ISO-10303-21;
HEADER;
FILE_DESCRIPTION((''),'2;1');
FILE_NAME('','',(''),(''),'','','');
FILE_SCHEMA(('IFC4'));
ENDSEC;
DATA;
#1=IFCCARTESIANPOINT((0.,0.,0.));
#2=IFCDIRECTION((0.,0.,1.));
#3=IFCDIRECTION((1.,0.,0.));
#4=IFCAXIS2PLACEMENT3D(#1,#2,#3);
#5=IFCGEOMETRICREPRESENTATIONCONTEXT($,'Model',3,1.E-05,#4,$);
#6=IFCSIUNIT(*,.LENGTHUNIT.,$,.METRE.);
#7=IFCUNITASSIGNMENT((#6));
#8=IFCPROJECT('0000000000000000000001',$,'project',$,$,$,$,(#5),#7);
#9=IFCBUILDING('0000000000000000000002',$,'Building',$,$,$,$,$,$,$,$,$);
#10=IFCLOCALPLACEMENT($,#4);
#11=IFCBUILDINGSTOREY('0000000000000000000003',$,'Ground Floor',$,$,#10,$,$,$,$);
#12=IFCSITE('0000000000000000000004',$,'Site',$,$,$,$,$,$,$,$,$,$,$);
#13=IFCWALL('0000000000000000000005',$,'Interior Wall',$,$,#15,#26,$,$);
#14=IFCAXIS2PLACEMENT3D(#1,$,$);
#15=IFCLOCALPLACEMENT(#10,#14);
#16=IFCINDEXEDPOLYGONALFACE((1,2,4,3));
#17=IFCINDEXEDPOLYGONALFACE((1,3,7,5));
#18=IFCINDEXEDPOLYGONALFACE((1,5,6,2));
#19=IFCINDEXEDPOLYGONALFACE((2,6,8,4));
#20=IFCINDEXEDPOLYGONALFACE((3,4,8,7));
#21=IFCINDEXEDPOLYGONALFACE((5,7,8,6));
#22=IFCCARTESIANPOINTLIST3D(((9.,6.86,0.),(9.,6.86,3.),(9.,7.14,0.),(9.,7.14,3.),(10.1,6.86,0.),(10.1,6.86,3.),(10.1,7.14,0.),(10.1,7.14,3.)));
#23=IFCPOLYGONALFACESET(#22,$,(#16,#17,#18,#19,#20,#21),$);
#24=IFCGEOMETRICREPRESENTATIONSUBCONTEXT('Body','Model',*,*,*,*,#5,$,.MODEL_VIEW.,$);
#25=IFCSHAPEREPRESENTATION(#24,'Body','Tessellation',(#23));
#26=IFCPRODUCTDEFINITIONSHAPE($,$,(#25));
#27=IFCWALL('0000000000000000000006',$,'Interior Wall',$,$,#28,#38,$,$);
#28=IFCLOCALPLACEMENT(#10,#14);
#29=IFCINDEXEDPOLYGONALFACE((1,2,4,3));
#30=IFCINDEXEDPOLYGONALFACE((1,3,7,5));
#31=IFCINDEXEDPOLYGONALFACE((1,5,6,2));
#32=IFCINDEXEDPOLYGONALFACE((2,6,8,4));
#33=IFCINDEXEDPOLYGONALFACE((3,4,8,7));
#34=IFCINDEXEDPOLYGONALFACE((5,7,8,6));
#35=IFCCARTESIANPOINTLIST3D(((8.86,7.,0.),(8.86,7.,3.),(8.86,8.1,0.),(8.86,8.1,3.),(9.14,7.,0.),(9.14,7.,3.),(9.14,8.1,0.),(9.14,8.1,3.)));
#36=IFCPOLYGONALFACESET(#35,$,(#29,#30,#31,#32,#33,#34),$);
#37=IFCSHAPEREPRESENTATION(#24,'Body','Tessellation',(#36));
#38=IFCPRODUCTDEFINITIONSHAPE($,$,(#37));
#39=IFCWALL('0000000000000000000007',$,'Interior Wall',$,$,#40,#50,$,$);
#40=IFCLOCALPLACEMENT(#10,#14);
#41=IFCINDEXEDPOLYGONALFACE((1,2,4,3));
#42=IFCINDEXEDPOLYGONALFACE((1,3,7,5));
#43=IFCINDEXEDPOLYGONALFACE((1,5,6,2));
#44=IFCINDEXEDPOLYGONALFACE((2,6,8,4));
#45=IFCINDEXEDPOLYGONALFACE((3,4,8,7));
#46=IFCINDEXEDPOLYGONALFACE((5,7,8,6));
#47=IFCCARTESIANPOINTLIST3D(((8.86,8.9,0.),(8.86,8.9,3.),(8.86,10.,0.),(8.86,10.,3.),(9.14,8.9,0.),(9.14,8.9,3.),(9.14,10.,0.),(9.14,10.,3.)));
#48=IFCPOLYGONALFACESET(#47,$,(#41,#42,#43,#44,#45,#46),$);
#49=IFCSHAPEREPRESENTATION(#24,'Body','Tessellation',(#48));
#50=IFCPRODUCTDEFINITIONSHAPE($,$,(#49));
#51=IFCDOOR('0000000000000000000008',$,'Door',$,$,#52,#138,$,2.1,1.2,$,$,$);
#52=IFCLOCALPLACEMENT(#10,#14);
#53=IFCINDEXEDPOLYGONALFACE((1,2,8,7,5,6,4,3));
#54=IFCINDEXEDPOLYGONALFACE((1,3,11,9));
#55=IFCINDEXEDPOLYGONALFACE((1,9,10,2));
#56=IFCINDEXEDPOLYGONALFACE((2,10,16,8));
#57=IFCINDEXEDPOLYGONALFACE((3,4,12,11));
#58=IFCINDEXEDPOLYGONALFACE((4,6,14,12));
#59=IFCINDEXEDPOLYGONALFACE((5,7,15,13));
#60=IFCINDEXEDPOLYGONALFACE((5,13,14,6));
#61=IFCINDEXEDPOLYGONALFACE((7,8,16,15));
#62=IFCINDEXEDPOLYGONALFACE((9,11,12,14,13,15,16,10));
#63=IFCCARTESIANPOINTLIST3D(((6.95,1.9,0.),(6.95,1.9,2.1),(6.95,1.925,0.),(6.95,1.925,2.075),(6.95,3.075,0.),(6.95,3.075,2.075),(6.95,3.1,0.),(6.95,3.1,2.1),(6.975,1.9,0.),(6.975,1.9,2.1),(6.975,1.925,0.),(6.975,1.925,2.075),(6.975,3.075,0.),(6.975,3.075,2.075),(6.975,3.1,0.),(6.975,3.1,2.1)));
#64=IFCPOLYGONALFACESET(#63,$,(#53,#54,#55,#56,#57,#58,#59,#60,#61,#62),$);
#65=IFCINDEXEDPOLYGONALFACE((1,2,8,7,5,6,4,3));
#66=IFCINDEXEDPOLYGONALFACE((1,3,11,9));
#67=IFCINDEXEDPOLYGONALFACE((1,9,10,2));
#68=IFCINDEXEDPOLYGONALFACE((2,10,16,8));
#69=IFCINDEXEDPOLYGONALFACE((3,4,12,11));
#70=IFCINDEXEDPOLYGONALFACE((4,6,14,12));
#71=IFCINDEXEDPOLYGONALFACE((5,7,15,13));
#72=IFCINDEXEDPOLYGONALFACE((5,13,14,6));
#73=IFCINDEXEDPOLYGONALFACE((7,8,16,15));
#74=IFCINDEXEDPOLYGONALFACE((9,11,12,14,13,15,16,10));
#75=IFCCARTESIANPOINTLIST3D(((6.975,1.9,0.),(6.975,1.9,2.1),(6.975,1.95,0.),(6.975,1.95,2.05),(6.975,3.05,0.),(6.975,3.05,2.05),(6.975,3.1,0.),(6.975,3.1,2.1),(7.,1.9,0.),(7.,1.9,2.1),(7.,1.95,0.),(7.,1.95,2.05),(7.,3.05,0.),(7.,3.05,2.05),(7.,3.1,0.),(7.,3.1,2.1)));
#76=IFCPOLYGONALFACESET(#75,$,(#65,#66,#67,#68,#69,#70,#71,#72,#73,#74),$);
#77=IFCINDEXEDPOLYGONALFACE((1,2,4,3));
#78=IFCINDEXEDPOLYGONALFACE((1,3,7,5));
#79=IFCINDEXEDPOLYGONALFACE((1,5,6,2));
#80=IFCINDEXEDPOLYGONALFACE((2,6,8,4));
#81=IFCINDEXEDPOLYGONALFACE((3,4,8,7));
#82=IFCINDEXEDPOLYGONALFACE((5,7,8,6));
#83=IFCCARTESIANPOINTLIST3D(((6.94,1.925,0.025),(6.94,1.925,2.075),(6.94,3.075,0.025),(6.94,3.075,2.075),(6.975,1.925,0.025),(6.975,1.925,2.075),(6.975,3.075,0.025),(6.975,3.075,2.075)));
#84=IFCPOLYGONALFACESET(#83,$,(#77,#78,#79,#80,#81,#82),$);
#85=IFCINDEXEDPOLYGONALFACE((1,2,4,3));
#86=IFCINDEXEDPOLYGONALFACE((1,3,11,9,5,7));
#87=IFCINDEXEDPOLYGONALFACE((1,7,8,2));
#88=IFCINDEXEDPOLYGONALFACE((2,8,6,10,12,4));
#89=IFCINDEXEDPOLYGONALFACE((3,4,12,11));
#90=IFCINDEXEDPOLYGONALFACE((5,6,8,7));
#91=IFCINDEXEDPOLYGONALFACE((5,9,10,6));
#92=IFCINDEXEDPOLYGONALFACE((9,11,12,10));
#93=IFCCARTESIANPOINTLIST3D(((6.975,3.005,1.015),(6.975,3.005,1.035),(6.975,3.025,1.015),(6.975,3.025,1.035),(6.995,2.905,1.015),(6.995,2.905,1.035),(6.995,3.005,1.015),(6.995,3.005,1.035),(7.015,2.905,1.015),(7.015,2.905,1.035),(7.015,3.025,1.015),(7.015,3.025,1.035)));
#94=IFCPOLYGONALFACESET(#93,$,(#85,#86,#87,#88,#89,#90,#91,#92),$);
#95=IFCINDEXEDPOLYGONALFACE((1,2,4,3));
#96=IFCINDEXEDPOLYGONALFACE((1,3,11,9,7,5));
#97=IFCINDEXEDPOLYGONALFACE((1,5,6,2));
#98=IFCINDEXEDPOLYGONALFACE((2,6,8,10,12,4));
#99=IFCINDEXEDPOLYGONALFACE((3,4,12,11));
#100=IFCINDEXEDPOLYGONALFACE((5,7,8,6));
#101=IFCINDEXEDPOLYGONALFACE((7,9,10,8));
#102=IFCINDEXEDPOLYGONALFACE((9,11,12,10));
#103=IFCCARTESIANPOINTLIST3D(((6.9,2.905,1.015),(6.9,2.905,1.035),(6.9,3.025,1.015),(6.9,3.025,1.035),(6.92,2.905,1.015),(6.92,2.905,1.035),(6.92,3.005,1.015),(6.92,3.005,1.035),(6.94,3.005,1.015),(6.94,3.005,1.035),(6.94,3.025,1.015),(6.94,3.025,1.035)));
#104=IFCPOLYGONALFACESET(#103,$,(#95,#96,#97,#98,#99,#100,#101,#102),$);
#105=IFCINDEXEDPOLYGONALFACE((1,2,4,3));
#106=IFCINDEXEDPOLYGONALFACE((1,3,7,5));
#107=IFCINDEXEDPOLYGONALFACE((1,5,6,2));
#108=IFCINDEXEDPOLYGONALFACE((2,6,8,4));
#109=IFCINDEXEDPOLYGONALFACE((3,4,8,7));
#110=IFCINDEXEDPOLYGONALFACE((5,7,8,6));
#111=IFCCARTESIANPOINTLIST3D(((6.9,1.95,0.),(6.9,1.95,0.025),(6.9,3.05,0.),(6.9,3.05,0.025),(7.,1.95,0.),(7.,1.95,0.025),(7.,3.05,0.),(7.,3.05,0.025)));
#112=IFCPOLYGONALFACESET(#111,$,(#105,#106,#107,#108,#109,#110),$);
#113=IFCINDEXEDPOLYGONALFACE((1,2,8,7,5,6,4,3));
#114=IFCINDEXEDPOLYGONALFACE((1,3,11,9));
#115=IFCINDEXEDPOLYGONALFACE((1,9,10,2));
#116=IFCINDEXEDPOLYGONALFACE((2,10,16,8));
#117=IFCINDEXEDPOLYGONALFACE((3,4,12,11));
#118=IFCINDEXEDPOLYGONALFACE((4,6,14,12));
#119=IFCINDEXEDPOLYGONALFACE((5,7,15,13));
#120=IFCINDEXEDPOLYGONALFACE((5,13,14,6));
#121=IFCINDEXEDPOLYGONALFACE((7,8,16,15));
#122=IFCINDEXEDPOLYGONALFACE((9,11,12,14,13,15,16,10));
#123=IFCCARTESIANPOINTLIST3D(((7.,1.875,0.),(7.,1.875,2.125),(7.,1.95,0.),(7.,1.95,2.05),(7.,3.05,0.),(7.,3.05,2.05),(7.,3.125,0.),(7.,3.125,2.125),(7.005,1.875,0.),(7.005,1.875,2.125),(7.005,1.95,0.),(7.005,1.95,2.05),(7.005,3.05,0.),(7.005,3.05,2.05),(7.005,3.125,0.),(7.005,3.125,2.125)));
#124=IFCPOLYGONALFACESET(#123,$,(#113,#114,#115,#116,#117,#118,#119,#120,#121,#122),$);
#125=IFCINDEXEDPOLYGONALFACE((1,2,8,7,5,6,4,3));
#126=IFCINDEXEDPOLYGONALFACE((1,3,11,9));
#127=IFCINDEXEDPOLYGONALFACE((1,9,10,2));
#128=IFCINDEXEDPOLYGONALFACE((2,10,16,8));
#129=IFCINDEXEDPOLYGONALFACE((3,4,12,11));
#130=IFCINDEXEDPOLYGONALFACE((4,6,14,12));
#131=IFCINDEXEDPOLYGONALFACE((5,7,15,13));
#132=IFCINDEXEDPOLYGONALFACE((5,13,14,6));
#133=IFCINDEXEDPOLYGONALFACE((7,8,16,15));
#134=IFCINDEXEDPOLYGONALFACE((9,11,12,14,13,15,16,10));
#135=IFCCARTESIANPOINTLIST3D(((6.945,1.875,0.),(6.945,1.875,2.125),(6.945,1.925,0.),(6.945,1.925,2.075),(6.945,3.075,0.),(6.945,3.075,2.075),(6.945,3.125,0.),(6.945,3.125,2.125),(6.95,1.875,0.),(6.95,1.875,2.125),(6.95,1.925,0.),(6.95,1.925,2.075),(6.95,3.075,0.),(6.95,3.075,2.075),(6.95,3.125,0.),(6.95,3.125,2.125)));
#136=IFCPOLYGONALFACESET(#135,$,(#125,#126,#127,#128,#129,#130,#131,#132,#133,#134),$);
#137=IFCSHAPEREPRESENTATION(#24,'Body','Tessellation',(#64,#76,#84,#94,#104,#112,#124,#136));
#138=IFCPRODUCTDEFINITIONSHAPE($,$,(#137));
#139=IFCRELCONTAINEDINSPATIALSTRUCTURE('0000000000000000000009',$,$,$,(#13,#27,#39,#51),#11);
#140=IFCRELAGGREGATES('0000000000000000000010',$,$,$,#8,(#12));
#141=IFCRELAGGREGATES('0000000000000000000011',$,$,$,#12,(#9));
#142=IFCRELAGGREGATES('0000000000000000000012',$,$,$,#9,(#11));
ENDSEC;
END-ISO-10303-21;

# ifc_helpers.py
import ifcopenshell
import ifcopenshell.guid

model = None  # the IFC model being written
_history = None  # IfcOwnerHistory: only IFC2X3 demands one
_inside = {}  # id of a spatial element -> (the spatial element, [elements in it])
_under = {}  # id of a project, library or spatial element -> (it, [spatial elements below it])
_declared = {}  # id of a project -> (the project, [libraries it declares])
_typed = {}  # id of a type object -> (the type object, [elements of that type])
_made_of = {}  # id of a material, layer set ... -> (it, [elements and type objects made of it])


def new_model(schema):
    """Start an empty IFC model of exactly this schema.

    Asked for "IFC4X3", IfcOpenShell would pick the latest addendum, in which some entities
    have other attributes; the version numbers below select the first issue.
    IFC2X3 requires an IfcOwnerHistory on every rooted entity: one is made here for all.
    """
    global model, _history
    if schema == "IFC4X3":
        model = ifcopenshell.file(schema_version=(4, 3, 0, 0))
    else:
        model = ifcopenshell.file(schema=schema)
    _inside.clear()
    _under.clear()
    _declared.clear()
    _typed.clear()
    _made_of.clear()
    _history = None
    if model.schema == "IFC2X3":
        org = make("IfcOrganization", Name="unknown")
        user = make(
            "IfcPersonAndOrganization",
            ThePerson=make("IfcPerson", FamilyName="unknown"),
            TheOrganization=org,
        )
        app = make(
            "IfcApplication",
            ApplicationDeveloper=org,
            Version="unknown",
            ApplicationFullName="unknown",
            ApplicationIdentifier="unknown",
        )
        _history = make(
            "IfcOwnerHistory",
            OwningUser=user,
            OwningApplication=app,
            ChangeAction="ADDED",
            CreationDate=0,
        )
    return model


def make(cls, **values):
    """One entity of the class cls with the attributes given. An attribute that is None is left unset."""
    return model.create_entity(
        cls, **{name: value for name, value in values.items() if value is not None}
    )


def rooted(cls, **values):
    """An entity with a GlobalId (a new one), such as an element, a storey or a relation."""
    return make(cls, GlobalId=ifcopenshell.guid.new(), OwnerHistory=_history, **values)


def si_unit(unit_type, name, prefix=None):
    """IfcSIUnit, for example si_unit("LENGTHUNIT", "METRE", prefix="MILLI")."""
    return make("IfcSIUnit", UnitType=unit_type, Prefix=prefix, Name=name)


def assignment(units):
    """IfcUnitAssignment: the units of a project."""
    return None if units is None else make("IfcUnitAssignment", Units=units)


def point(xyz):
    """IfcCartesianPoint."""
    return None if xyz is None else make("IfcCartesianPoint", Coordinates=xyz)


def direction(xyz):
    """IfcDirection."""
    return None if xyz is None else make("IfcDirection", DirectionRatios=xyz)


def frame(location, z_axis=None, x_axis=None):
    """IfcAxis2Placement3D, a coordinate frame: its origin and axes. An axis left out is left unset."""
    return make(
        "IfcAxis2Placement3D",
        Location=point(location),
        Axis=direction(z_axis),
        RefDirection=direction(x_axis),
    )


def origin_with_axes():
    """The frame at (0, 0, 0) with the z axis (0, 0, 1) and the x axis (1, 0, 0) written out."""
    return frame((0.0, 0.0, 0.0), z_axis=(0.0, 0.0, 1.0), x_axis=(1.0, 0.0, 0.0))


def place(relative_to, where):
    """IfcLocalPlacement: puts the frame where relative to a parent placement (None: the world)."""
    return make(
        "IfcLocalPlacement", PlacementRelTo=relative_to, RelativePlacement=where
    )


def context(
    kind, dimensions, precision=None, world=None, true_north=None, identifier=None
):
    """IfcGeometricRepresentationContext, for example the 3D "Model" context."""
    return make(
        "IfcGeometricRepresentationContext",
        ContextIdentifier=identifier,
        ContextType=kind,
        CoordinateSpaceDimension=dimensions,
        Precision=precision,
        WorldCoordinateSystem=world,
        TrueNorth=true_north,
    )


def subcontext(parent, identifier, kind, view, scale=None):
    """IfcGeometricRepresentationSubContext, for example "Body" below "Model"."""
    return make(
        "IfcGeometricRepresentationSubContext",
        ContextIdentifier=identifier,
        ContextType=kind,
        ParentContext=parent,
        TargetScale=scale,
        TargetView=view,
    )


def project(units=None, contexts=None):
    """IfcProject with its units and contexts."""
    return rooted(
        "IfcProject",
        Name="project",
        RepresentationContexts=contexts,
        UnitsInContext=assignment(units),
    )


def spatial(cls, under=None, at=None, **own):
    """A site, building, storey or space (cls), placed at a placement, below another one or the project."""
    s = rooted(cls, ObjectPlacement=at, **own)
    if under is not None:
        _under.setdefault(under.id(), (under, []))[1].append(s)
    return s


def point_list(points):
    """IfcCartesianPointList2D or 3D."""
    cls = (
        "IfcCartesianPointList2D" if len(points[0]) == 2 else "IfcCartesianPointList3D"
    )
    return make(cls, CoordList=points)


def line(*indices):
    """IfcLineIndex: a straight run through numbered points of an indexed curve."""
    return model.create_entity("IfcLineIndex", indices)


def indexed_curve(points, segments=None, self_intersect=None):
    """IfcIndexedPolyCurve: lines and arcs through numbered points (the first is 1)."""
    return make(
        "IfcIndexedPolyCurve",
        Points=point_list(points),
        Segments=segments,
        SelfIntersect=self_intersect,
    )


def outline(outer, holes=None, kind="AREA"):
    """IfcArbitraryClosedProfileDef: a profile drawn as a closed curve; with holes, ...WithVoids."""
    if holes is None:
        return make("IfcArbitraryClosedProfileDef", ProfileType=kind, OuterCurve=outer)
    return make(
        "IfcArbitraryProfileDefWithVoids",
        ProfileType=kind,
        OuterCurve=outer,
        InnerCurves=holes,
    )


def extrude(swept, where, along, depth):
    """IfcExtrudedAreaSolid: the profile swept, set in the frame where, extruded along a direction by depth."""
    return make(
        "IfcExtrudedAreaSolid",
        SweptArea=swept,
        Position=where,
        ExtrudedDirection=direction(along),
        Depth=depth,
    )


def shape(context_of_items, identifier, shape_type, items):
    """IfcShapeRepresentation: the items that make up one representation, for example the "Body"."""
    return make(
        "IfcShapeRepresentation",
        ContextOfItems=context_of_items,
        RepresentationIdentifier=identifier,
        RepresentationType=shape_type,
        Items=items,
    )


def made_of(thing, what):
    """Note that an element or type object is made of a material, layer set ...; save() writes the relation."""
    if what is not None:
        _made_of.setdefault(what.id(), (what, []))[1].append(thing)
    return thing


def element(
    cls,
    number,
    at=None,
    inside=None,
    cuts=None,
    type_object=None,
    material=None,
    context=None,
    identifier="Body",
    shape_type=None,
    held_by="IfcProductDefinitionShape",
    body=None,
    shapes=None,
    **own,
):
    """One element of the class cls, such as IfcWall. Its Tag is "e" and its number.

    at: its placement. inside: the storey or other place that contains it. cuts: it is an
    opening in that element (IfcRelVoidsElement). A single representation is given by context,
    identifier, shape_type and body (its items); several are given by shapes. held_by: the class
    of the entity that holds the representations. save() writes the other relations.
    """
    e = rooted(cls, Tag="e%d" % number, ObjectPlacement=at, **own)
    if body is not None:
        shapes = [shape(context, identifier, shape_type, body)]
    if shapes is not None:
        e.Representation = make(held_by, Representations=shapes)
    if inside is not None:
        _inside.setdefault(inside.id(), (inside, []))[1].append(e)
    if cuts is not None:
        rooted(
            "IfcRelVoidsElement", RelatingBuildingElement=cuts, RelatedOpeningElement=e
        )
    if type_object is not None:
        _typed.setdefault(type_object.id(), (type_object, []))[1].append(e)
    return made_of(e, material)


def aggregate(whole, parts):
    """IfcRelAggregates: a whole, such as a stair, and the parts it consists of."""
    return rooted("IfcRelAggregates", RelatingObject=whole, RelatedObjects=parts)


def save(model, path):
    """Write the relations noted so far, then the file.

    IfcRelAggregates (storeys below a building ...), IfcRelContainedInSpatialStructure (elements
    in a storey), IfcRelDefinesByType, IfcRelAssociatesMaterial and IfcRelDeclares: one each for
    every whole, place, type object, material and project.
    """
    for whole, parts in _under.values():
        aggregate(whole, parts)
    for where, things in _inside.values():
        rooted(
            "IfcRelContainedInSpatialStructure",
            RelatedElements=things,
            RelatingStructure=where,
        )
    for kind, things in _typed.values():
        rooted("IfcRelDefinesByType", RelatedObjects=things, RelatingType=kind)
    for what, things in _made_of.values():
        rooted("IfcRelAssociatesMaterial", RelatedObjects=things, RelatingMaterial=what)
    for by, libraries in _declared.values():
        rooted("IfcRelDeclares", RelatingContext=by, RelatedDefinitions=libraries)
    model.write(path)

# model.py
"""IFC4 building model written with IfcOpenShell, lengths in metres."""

from ifc_helpers import new_model, si_unit, frame, origin_with_axes, place, context, subcontext, project, spatial, line, indexed_curve, outline, extrude, element, save


model = new_model("IFC4")

# Units and contexts
model_context = context("Model", 3, precision=1e-05, world=origin_with_axes())
body_context = subcontext(model_context, "Body", "Model", "MODEL_VIEW")
ifc_project = project(units=[si_unit("LENGTHUNIT", "METRE")], contexts=[model_context])

# Site, building, storey
site = spatial("IfcSite", under=ifc_project, Name="Site")
building = spatial("IfcBuilding", under=site, Name="Building")
storey_placement = place(None, origin_with_axes())
storey = spatial("IfcBuildingStorey", under=building, at=storey_placement, Name="Ground Floor")

# Walls
for number, where, z_axis, x_axis, name in (
    (1, (10.1, 7.0, 0.0), (0.0, 0.0, 1.0), (-1.0, 0.0, 0.0), "Interior Wall"),
    (2, (9.0, 7.0, 0.0), (0.0, 0.0, 1.0), (0.0, 1.0, 0.0), "Interior Wall"),
    (3, (9.0, 8.9, 0.0), (0.0, 0.0, 1.0), (0.0, 1.0, 0.0), "Interior Wall"),
):
    element("IfcWall", number, at=place(storey_placement, frame(where, z_axis=z_axis, x_axis=x_axis)), inside=storey, Name=name, context=body_context, shape_type="SweptSolid", body=[
        extrude(outline(indexed_curve([(0.0, 0.0), (0.0, 0.28), (1.1, 0.28), (1.1, 0.0), (0.0, 0.0)], self_intersect=False)), frame((0.0, -0.14, 0.0), z_axis=(0.0, 0.0, 1.0), x_axis=(1.0, 0.0, 0.0)), (0.0, 0.0, 1.0), 3.0),
    ])

# Door
door_1_placement = place(storey_placement, frame((7.0, 1.9, 0.0), z_axis=(0.0, 0.0, 1.0), x_axis=(0.0, 1.0, 0.0)))
element("IfcDoor", 4, at=door_1_placement, inside=storey, Name="Door", OverallHeight=2.1, OverallWidth=1.2, context=body_context, shape_type="SweptSolid", body=[
    extrude(outline(indexed_curve([(0.0, 0.0), (0.0, 2.1), (1.2, 2.1), (1.2, 0.0), (1.175, 0.0), (1.175, 2.075), (0.025, 2.075), (0.025, 0.0)], segments=[line(1, 2, 3, 4, 5, 6, 7, 8, 1)])), frame((0.0, 0.025, 0.0), z_axis=(0.0, -1.0, 0.0), x_axis=(1.0, 0.0, 0.0)), (0.0, 0.0, -1.0), 0.025),
    extrude(outline(indexed_curve([(0.0, 0.0), (0.0, 2.1), (1.2, 2.1), (1.2, 0.0), (1.15, 0.0), (1.15, 2.05), (0.05, 2.05), (0.05, 0.0)], segments=[line(1, 2, 3, 4, 5, 6, 7, 8, 1)])), frame((0.0, 0.0, 0.0), z_axis=(0.0, -1.0, 0.0), x_axis=(1.0, 0.0, 0.0)), (0.0, 0.0, -1.0), 0.025),
    extrude(outline(indexed_curve([(0.0, 0.0), (1.15, 0.0), (1.15, 0.035), (0.0, 0.035)], segments=[line(1, 2, 3, 4, 1)])), frame((0.025, 0.025, 0.025), z_axis=(0.0, 0.0, 1.0), x_axis=(1.0, 0.0, 0.0)), (0.0, 0.0, 1.0), 2.05),
    extrude(outline(indexed_curve([(0.0, 0.0), (0.0, -0.04), (-0.12, -0.04), (-0.12, -0.02), (-0.02, -0.02), (-0.02, 0.0)], segments=[line(1, 2, 3, 4, 5, 6, 1)])), frame((1.125, 0.025, 1.015), z_axis=(0.0, 0.0, 1.0), x_axis=(1.0, 0.0, 0.0)), (0.0, 0.0, 1.0), 0.02),
    extrude(outline(indexed_curve([(0.0, 0.0), (0.0, 0.04), (-0.12, 0.04), (-0.12, 0.02), (-0.02, 0.02), (-0.02, 0.0)], segments=[line(1, 2, 3, 4, 5, 6, 1)])), frame((1.125, 0.06, 1.015), z_axis=(0.0, 0.0, 1.0), x_axis=(1.0, 0.0, 0.0)), (0.0, 0.0, 1.0), 0.02),
    extrude(outline(indexed_curve([(0.0, 0.0), (1.1, 0.0), (1.1, 0.1), (0.0, 0.1)], segments=[line(1, 2, 3, 4, 1)])), frame((0.05, 0.0, 0.0), z_axis=(0.0, 0.0, 1.0), x_axis=(1.0, 0.0, 0.0)), (0.0, 0.0, 1.0), 0.025),
    extrude(outline(indexed_curve([(0.0, 0.0), (0.0, 2.125), (1.25, 2.125), (1.25, 0.0), (1.175, 0.0), (1.175, 2.05), (0.075, 2.05), (0.075, 0.0)], segments=[line(1, 2, 3, 4, 5, 6, 7, 8, 1)])), frame((-0.025, -0.005, 0.0), z_axis=(0.0, -1.0, 0.0), x_axis=(1.0, 0.0, 0.0)), (0.0, 0.0, -1.0), 0.005),
    extrude(outline(indexed_curve([(0.0, 0.0), (0.0, 2.125), (1.25, 2.125), (1.25, 0.0), (1.2, 0.0), (1.2, 2.075), (0.05, 2.075), (0.05, 0.0)], segments=[line(1, 2, 3, 4, 5, 6, 7, 8, 1)])), frame((-0.025, 0.05, 0.0), z_axis=(0.0, -1.0, 0.0), x_axis=(1.0, 0.0, 0.0)), (0.0, 0.0, -1.0), 0.005),
])

save(model, "model.ifc")
